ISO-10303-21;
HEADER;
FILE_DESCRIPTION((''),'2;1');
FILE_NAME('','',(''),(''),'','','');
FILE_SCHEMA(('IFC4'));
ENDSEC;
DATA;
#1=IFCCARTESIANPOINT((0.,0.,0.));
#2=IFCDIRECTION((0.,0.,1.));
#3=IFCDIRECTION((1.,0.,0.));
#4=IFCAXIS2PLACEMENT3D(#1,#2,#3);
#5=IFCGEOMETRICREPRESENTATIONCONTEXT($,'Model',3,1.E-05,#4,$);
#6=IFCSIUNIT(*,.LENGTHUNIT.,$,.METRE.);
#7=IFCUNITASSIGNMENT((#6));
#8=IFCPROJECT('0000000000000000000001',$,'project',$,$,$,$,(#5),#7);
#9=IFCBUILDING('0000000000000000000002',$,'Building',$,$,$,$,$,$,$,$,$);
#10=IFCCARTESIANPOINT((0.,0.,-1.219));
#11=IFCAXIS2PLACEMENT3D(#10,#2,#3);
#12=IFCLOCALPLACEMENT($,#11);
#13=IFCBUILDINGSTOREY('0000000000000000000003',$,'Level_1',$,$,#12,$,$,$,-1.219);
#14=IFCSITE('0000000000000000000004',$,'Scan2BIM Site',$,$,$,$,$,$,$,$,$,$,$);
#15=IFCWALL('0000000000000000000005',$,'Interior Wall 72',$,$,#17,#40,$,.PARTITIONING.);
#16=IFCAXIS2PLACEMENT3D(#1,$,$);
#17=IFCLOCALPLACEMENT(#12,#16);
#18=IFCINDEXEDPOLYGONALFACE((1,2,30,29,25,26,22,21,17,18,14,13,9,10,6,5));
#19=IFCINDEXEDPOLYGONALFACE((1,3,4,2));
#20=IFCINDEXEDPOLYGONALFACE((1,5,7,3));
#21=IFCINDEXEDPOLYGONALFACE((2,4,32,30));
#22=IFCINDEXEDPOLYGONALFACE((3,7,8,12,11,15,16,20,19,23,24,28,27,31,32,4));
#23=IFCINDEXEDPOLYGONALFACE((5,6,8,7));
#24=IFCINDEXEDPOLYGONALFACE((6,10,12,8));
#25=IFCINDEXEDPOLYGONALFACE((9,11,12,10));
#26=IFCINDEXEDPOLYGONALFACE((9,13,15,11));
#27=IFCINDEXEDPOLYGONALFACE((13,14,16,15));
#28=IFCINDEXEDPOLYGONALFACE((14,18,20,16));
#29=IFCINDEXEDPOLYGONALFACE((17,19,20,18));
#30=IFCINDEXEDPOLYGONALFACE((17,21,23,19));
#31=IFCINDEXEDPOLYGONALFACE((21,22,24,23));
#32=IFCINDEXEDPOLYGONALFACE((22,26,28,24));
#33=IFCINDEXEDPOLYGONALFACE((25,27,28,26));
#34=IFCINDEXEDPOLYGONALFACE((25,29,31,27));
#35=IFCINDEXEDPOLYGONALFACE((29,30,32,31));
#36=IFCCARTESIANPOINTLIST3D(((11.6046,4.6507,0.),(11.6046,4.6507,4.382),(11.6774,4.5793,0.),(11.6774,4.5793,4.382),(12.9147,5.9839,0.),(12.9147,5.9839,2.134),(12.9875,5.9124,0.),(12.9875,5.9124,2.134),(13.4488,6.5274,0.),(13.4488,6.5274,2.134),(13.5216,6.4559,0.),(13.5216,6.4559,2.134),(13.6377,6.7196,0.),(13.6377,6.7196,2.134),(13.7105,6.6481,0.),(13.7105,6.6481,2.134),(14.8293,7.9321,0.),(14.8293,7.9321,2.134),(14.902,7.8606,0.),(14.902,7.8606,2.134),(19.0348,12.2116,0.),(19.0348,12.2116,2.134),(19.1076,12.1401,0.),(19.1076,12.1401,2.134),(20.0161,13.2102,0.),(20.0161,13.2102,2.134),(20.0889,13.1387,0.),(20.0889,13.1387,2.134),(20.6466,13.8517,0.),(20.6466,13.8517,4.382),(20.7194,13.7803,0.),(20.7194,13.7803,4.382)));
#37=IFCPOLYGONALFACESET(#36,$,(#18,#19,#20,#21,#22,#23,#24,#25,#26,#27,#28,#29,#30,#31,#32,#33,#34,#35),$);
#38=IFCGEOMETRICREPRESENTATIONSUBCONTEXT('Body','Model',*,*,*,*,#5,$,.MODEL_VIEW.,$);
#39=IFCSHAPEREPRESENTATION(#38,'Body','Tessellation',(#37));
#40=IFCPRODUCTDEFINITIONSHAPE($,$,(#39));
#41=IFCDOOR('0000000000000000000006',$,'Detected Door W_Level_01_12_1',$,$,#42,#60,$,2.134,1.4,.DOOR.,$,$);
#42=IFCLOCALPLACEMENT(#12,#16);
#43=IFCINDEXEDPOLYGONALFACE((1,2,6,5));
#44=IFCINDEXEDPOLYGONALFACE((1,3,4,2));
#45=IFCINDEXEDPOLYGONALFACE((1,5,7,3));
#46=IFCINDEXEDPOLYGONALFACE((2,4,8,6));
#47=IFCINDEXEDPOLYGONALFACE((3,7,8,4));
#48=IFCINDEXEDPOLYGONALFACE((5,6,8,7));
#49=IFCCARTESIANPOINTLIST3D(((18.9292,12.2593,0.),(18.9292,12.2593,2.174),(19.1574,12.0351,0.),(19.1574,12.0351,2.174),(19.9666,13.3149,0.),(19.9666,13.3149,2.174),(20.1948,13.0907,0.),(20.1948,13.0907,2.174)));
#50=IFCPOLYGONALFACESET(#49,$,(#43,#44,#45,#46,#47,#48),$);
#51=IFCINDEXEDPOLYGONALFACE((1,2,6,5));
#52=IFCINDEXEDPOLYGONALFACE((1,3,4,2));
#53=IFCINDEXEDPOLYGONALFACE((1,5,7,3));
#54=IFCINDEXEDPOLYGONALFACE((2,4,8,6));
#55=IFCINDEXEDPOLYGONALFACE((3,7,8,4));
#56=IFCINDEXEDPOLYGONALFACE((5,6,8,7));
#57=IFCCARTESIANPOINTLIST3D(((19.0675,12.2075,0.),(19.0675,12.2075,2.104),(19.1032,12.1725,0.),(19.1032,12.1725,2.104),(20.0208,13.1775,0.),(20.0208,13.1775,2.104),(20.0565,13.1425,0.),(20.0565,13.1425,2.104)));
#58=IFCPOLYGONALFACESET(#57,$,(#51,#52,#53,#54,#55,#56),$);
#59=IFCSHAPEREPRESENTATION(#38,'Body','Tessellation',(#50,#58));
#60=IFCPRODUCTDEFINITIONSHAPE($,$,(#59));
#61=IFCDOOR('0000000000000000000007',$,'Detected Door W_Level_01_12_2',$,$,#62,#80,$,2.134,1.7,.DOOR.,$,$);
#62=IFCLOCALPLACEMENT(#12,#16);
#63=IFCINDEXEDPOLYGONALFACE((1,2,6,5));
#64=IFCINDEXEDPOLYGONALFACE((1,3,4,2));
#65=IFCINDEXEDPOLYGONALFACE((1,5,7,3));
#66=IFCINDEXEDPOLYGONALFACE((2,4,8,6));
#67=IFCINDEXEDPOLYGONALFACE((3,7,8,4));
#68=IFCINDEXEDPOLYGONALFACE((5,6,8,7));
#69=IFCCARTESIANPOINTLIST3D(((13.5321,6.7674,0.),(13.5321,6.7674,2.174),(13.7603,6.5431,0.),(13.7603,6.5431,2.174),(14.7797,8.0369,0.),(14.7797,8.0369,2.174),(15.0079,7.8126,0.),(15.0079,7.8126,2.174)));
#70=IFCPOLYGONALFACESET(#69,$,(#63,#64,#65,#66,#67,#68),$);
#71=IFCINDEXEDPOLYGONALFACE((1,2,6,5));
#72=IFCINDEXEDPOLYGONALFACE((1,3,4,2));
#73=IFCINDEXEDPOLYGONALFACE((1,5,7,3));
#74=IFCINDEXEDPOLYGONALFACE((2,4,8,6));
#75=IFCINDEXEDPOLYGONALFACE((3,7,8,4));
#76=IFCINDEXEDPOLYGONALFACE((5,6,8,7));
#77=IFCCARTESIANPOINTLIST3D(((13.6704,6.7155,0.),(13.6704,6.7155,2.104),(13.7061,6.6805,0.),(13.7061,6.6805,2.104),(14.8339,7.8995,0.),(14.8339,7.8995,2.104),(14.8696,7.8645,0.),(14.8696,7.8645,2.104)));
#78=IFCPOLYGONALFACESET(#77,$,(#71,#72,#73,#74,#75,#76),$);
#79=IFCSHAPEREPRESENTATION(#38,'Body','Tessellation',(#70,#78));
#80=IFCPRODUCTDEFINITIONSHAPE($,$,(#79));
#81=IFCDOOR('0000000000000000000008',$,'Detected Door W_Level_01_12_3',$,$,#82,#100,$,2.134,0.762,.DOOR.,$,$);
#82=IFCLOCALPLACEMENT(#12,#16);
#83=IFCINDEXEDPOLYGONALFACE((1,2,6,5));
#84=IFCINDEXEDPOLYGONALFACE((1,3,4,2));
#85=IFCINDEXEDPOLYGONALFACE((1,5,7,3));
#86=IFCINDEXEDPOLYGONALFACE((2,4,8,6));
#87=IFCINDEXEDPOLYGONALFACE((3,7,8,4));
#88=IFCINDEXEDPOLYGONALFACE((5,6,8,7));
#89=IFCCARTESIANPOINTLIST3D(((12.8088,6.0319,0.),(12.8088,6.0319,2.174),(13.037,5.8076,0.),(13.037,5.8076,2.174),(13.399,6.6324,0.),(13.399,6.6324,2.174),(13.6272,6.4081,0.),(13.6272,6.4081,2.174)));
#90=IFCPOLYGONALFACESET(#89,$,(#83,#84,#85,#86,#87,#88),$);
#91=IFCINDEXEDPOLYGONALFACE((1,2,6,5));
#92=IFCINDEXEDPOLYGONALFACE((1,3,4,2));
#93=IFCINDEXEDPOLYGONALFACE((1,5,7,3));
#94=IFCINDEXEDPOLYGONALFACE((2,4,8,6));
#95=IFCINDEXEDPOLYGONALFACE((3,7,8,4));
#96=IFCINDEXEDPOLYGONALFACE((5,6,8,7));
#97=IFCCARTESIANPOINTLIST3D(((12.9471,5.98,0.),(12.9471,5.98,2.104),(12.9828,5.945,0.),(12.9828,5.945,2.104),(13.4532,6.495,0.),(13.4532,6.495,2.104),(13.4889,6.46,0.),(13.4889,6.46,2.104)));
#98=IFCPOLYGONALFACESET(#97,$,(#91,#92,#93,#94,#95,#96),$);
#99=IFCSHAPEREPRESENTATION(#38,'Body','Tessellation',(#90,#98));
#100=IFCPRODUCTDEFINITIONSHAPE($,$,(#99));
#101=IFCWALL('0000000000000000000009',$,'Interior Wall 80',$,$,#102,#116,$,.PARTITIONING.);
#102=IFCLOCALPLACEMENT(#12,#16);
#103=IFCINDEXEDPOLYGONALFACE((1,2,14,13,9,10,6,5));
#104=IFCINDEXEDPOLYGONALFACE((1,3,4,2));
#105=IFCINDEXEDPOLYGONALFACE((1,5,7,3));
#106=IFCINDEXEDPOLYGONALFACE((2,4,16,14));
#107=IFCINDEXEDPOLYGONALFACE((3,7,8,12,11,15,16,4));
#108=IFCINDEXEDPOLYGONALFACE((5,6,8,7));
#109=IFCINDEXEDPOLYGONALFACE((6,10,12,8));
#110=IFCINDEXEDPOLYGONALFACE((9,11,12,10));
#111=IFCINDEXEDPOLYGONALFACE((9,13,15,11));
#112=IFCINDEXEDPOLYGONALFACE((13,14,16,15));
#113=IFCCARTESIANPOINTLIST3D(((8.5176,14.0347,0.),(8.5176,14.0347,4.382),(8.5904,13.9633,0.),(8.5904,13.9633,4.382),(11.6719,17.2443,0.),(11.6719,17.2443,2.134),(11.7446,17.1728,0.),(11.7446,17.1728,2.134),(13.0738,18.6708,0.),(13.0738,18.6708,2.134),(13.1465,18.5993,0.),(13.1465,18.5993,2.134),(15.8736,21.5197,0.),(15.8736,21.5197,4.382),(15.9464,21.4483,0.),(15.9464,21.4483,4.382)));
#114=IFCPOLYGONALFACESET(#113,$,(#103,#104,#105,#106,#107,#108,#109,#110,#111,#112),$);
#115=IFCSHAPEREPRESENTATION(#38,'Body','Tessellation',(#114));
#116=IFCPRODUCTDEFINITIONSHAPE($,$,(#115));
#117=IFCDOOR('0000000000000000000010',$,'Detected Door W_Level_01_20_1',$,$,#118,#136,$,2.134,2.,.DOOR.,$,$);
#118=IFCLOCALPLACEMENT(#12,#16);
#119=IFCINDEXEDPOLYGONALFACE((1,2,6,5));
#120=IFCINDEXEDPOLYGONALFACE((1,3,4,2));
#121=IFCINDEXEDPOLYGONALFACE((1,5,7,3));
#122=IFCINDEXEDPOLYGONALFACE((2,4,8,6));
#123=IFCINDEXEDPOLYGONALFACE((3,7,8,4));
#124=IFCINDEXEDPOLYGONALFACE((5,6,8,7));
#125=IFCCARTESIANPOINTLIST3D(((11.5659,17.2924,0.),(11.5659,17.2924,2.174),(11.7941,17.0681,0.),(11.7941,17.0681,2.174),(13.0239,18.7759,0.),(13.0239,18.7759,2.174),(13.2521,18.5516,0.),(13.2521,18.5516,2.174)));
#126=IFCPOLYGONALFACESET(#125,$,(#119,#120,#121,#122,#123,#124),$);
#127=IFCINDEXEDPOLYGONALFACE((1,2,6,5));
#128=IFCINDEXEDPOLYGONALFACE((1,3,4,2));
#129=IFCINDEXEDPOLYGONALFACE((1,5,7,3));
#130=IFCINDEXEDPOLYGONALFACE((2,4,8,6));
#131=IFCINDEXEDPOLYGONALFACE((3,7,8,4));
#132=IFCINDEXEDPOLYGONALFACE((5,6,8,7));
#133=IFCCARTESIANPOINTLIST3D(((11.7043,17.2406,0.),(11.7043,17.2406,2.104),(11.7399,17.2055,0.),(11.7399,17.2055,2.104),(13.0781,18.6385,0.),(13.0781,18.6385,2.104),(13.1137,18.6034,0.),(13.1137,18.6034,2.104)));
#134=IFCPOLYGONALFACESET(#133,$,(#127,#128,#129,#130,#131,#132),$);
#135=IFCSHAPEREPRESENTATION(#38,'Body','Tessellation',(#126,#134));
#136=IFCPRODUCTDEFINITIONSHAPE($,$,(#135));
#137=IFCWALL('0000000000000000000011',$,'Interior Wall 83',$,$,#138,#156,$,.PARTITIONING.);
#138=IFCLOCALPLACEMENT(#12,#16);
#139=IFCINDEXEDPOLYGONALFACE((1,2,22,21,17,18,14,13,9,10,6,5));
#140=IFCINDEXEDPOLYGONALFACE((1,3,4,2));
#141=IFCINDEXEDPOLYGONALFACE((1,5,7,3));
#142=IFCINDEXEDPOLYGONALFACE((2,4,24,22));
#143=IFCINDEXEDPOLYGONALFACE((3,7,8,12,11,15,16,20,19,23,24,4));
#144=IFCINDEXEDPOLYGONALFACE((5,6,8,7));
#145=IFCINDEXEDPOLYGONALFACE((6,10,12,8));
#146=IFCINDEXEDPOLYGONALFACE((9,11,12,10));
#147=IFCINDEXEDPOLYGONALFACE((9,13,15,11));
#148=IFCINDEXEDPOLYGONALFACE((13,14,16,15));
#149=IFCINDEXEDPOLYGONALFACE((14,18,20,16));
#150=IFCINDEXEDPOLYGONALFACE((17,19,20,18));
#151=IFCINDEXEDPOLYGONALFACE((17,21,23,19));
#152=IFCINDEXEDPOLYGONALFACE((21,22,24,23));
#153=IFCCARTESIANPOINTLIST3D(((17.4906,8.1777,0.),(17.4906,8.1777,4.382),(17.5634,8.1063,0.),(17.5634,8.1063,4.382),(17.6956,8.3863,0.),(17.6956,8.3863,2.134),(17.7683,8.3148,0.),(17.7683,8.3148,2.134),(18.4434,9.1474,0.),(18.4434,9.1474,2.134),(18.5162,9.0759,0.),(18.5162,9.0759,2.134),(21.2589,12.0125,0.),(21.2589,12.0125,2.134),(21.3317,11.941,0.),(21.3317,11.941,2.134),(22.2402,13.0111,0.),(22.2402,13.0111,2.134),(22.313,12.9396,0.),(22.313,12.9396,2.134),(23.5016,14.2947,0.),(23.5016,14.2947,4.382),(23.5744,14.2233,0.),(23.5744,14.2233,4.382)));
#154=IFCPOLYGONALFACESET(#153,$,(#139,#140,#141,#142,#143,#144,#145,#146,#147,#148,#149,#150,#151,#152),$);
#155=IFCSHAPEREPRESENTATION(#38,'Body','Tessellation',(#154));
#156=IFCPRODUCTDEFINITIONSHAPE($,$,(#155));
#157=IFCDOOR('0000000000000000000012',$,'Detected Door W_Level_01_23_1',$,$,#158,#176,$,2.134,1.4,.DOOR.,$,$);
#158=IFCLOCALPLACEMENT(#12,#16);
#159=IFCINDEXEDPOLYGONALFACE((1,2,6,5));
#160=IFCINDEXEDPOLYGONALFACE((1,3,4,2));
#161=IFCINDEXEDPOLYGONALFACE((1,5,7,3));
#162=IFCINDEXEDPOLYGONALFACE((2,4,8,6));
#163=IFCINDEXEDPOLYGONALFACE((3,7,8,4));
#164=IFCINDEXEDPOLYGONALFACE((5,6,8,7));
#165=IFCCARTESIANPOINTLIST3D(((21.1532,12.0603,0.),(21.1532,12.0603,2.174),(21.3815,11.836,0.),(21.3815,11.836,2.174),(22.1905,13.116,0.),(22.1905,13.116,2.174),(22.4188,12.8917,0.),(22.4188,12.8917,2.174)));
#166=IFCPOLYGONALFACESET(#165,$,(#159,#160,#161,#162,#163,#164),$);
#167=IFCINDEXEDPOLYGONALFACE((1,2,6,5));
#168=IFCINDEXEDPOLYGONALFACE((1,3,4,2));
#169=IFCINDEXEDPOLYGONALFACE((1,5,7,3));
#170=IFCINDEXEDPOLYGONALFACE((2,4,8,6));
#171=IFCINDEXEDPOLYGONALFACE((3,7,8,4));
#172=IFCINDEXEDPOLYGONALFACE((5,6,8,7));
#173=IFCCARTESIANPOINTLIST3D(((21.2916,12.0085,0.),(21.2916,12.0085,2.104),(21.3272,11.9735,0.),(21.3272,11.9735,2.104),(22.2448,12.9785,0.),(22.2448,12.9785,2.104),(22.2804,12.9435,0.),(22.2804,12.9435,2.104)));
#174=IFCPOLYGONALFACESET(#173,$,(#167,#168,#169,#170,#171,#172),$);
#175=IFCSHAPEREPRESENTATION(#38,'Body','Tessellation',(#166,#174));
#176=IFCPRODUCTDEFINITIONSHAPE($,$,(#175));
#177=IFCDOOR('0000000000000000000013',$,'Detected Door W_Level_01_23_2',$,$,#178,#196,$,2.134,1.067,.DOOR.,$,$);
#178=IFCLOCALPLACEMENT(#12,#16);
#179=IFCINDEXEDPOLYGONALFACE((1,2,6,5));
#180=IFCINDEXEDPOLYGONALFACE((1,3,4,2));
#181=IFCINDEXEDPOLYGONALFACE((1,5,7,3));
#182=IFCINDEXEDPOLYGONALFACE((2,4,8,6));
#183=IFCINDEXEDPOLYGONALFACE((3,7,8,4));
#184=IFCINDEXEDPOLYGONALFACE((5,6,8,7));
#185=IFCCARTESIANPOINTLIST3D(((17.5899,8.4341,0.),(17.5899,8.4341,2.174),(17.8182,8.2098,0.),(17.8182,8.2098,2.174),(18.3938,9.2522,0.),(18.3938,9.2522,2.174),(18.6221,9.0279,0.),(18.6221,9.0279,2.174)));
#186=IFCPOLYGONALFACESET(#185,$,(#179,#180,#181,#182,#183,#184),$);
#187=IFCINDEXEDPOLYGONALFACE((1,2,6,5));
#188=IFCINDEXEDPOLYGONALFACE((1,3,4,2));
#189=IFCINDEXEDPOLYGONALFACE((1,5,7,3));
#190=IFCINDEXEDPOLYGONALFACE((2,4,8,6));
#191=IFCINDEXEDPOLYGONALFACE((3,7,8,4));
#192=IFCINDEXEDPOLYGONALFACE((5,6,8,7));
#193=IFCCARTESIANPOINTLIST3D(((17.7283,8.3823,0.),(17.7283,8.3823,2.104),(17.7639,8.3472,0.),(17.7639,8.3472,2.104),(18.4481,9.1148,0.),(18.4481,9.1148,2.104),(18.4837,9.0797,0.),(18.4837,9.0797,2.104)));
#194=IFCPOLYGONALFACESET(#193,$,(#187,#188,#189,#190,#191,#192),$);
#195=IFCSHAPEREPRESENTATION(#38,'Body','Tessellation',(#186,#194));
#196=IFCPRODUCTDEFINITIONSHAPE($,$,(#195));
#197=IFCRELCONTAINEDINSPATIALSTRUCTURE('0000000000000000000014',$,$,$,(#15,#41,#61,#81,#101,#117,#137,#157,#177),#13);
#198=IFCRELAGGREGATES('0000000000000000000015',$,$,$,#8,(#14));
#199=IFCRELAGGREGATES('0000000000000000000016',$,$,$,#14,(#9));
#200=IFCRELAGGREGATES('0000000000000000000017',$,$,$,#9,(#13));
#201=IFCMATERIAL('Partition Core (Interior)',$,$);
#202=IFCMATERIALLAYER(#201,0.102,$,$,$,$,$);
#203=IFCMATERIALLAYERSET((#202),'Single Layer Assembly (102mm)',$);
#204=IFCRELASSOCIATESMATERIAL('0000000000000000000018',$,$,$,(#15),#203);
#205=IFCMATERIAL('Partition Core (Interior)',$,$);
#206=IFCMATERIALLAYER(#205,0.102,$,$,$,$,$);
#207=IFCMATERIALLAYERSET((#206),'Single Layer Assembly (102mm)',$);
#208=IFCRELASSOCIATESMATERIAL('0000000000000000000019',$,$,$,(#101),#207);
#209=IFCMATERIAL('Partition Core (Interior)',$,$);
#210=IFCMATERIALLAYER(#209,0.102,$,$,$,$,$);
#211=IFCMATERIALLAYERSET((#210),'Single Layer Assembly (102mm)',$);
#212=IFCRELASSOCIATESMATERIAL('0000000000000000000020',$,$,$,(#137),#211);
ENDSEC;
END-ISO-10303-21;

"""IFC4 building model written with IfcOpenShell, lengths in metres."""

from ifc_helpers import new_model, si_unit, frame, origin, origin_with_axes, place, context, subcontext, project, spatial, rectangle, extrude, material, layer, layer_set, element, fill, save


model = new_model("IFC4")

# Units and contexts
model_context = context("Model", 3, precision=1e-05, world=origin_with_axes())
body_context = subcontext(model_context, "Body", "Model", "MODEL_VIEW")
ifc_project = project(units=[si_unit("LENGTHUNIT", "METRE")], contexts=[model_context])

# Site, building, storey
site = spatial("IfcSite", under=ifc_project, Name="Scan2BIM Site")
building = spatial("IfcBuilding", under=site, Name="Building")
storey_placement = place(None, frame((0.0, 0.0, -1.219), z_axis=(0.0, 0.0, 1.0), x_axis=(1.0, 0.0, 0.0)))
storey = spatial("IfcBuildingStorey", under=building, at=storey_placement, Name="Level_1", Elevation=-1.219)

# Wall, openings, doors
ifc_material_1 = material(Name="Partition Core (Interior)")
ifc_layer_1 = layer(ifc_material_1, 0.102)
ifc_layer_set_1 = layer_set([ifc_layer_1], Name="Single Layer Assembly (102mm)")
wall_1_placement = place(storey_placement, frame((16.162, 9.2155, 0.0), z_axis=(0.0, 0.0, 1.0), x_axis=(-0.700917, -0.713243, 0.0)))
wall_1 = element("IfcWall", 1, at=wall_1_placement, inside=storey, material=ifc_layer_set_1, Name="Interior Wall 72", PredefinedType="PARTITIONING", context=body_context, shape_type="SweptSolid", body=[
    extrude(rectangle(XDim=12.9002, YDim=0.102), origin(), (0.0, 0.0, 1.0), 4.382),
])
opening_1_placement = place(None, frame((19.562, 12.675, -1.219), z_axis=(0.0, 0.0, 1.0), x_axis=(-0.700917, -0.713243, 0.0)))
opening_1 = element("IfcOpeningElement", 2, at=opening_1_placement, cuts=wall_1, PredefinedType="OPENING", context=body_context, shape_type="SweptSolid", body=[
    extrude(rectangle(XDim=1.4, YDim=0.202), origin(), (0.0, 0.0, 1.0), 2.134),
])
opening_2_placement = place(None, frame((14.27, 7.29, -1.219), z_axis=(0.0, 0.0, 1.0), x_axis=(-0.700917, -0.713243, 0.0)))
opening_2 = element("IfcOpeningElement", 3, at=opening_2_placement, cuts=wall_1, PredefinedType="OPENING", context=body_context, shape_type="SweptSolid", body=[
    extrude(rectangle(XDim=1.7, YDim=0.202), origin(), (0.0, 0.0, 1.0), 2.134),
])
opening_3_placement = place(None, frame((13.218, 6.22, -1.219), z_axis=(0.0, 0.0, 1.0), x_axis=(-0.700917, -0.713243, 0.0)))
opening_3 = element("IfcOpeningElement", 4, at=opening_3_placement, cuts=wall_1, PredefinedType="OPENING", context=body_context, shape_type="SweptSolid", body=[
    extrude(rectangle(XDim=0.762, YDim=0.202), origin(), (0.0, 0.0, 1.0), 2.134),
])
door_1_placement = place(opening_1_placement, frame((0.0, 0.0, 0.0), z_axis=(0.0, 0.0, 1.0), x_axis=(1.0, 0.0, 0.0)))
door_1 = element("IfcDoor", 5, at=door_1_placement, inside=storey, Name="Detected Door W_Level_01_12_1", OverallHeight=2.134, OverallWidth=1.4, PredefinedType="DOOR", context=body_context, shape_type="SweptSolid", body=[
    extrude(rectangle(XDim=1.48, YDim=0.32), origin(), (0.0, 0.0, 1.0), 2.174),
    extrude(rectangle(XDim=1.36, YDim=0.05), origin(), (0.0, 0.0, 1.0), 2.104),
])
fill(opening_1, door_1)
door_2_placement = place(opening_2_placement, frame((0.0, 0.0, 0.0), z_axis=(0.0, 0.0, 1.0), x_axis=(1.0, 0.0, 0.0)))
door_2 = element("IfcDoor", 6, at=door_2_placement, inside=storey, Name="Detected Door W_Level_01_12_2", OverallHeight=2.134, OverallWidth=1.7, PredefinedType="DOOR", context=body_context, shape_type="SweptSolid", body=[
    extrude(rectangle(XDim=1.78, YDim=0.32), origin(), (0.0, 0.0, 1.0), 2.174),
    extrude(rectangle(XDim=1.66, YDim=0.05), origin(), (0.0, 0.0, 1.0), 2.104),
])
fill(opening_2, door_2)
door_3_placement = place(opening_3_placement, frame((0.0, 0.0, 0.0), z_axis=(0.0, 0.0, 1.0), x_axis=(1.0, 0.0, 0.0)))
door_3 = element("IfcDoor", 7, at=door_3_placement, inside=storey, Name="Detected Door W_Level_01_12_3", OverallHeight=2.134, OverallWidth=0.762, PredefinedType="DOOR", context=body_context, shape_type="SweptSolid", body=[
    extrude(rectangle(XDim=0.842, YDim=0.32), origin(), (0.0, 0.0, 1.0), 2.174),
    extrude(rectangle(XDim=0.722, YDim=0.05), origin(), (0.0, 0.0, 1.0), 2.104),
])
fill(opening_3, door_3)

# Wall, opening, door
ifc_material_2 = material(Name="Partition Core (Interior)")
ifc_layer_2 = layer(ifc_material_2, 0.102)
ifc_layer_set_2 = layer_set([ifc_layer_2], Name="Single Layer Assembly (102mm)")
wall_2_placement = place(storey_placement, frame((12.232, 17.7415, 0.0), z_axis=(0.0, 0.0, 1.0), x_axis=(0.700934, 0.713226, 0.0)))
wall_2 = element("IfcWall", 8, at=wall_2_placement, inside=storey, material=ifc_layer_set_2, Name="Interior Wall 80", PredefinedType="PARTITIONING", context=body_context, shape_type="SweptSolid", body=[
    extrude(rectangle(XDim=10.4946, YDim=0.102), origin(), (0.0, 0.0, 1.0), 4.382),
])
opening_4_placement = place(None, frame((12.409, 17.922, -1.219), z_axis=(0.0, 0.0, 1.0), x_axis=(0.700934, 0.713226, 0.0)))
opening_4 = element("IfcOpeningElement", 9, at=opening_4_placement, cuts=wall_2, PredefinedType="OPENING", context=body_context, shape_type="SweptSolid", body=[
    extrude(rectangle(XDim=2.0, YDim=0.202), origin(), (0.0, 0.0, 1.0), 2.134),
])
door_4_placement = place(opening_4_placement, frame((0.0, 0.0, 0.0), z_axis=(0.0, 0.0, 1.0), x_axis=(1.0, 0.0, 0.0)))
door_4 = element("IfcDoor", 10, at=door_4_placement, inside=storey, Name="Detected Door W_Level_01_20_1", OverallHeight=2.134, OverallWidth=2.0, PredefinedType="DOOR", context=body_context, shape_type="SweptSolid", body=[
    extrude(rectangle(XDim=2.08, YDim=0.32), origin(), (0.0, 0.0, 1.0), 2.174),
    extrude(rectangle(XDim=1.96, YDim=0.05), origin(), (0.0, 0.0, 1.0), 2.104),
])
fill(opening_4, door_4)

# Wall, openings, doors
ifc_material_3 = material(Name="Partition Core (Interior)")
ifc_layer_3 = layer(ifc_material_3, 0.102)
ifc_layer_set_3 = layer_set([ifc_layer_3], Name="Single Layer Assembly (102mm)")
wall_3_placement = place(storey_placement, frame((20.5325, 11.2005, 0.0), z_axis=(0.0, 0.0, 1.0), x_axis=(-0.7009, -0.71326, 0.0)))
wall_3 = element("IfcWall", 11, at=wall_3_placement, inside=storey, material=ifc_layer_set_3, Name="Interior Wall 83", PredefinedType="PARTITIONING", context=body_context, shape_type="SweptSolid", body=[
    extrude(rectangle(XDim=8.5761, YDim=0.102), origin(), (0.0, 0.0, 1.0), 4.382),
])
opening_5_placement = place(None, frame((21.786, 12.476, -1.219), z_axis=(0.0, 0.0, 1.0), x_axis=(-0.7009, -0.71326, 0.0)))
opening_5 = element("IfcOpeningElement", 12, at=opening_5_placement, cuts=wall_3, PredefinedType="OPENING", context=body_context, shape_type="SweptSolid", body=[
    extrude(rectangle(XDim=1.4, YDim=0.202), origin(), (0.0, 0.0, 1.0), 2.134),
])
opening_6_placement = place(None, frame((18.106, 8.731, -1.219), z_axis=(0.0, 0.0, 1.0), x_axis=(-0.7009, -0.71326, 0.0)))
opening_6 = element("IfcOpeningElement", 13, at=opening_6_placement, cuts=wall_3, PredefinedType="OPENING", context=body_context, shape_type="SweptSolid", body=[
    extrude(rectangle(XDim=1.067, YDim=0.202), origin(), (0.0, 0.0, 1.0), 2.134),
])
door_5_placement = place(opening_5_placement, frame((0.0, 0.0, 0.0), z_axis=(0.0, 0.0, 1.0), x_axis=(1.0, 0.0, 0.0)))
door_5 = element("IfcDoor", 14, at=door_5_placement, inside=storey, Name="Detected Door W_Level_01_23_1", OverallHeight=2.134, OverallWidth=1.4, PredefinedType="DOOR", context=body_context, shape_type="SweptSolid", body=[
    extrude(rectangle(XDim=1.48, YDim=0.32), origin(), (0.0, 0.0, 1.0), 2.174),
    extrude(rectangle(XDim=1.36, YDim=0.05), origin(), (0.0, 0.0, 1.0), 2.104),
])
fill(opening_5, door_5)
door_6_placement = place(opening_6_placement, frame((0.0, 0.0, 0.0), z_axis=(0.0, 0.0, 1.0), x_axis=(1.0, 0.0, 0.0)))
door_6 = element("IfcDoor", 15, at=door_6_placement, inside=storey, Name="Detected Door W_Level_01_23_2", OverallHeight=2.134, OverallWidth=1.067, PredefinedType="DOOR", context=body_context, shape_type="SweptSolid", body=[
    extrude(rectangle(XDim=1.147, YDim=0.32), origin(), (0.0, 0.0, 1.0), 2.174),
    extrude(rectangle(XDim=1.027, YDim=0.05), origin(), (0.0, 0.0, 1.0), 2.104),
])
fill(opening_6, door_6)

save(model, "model.ifc")
